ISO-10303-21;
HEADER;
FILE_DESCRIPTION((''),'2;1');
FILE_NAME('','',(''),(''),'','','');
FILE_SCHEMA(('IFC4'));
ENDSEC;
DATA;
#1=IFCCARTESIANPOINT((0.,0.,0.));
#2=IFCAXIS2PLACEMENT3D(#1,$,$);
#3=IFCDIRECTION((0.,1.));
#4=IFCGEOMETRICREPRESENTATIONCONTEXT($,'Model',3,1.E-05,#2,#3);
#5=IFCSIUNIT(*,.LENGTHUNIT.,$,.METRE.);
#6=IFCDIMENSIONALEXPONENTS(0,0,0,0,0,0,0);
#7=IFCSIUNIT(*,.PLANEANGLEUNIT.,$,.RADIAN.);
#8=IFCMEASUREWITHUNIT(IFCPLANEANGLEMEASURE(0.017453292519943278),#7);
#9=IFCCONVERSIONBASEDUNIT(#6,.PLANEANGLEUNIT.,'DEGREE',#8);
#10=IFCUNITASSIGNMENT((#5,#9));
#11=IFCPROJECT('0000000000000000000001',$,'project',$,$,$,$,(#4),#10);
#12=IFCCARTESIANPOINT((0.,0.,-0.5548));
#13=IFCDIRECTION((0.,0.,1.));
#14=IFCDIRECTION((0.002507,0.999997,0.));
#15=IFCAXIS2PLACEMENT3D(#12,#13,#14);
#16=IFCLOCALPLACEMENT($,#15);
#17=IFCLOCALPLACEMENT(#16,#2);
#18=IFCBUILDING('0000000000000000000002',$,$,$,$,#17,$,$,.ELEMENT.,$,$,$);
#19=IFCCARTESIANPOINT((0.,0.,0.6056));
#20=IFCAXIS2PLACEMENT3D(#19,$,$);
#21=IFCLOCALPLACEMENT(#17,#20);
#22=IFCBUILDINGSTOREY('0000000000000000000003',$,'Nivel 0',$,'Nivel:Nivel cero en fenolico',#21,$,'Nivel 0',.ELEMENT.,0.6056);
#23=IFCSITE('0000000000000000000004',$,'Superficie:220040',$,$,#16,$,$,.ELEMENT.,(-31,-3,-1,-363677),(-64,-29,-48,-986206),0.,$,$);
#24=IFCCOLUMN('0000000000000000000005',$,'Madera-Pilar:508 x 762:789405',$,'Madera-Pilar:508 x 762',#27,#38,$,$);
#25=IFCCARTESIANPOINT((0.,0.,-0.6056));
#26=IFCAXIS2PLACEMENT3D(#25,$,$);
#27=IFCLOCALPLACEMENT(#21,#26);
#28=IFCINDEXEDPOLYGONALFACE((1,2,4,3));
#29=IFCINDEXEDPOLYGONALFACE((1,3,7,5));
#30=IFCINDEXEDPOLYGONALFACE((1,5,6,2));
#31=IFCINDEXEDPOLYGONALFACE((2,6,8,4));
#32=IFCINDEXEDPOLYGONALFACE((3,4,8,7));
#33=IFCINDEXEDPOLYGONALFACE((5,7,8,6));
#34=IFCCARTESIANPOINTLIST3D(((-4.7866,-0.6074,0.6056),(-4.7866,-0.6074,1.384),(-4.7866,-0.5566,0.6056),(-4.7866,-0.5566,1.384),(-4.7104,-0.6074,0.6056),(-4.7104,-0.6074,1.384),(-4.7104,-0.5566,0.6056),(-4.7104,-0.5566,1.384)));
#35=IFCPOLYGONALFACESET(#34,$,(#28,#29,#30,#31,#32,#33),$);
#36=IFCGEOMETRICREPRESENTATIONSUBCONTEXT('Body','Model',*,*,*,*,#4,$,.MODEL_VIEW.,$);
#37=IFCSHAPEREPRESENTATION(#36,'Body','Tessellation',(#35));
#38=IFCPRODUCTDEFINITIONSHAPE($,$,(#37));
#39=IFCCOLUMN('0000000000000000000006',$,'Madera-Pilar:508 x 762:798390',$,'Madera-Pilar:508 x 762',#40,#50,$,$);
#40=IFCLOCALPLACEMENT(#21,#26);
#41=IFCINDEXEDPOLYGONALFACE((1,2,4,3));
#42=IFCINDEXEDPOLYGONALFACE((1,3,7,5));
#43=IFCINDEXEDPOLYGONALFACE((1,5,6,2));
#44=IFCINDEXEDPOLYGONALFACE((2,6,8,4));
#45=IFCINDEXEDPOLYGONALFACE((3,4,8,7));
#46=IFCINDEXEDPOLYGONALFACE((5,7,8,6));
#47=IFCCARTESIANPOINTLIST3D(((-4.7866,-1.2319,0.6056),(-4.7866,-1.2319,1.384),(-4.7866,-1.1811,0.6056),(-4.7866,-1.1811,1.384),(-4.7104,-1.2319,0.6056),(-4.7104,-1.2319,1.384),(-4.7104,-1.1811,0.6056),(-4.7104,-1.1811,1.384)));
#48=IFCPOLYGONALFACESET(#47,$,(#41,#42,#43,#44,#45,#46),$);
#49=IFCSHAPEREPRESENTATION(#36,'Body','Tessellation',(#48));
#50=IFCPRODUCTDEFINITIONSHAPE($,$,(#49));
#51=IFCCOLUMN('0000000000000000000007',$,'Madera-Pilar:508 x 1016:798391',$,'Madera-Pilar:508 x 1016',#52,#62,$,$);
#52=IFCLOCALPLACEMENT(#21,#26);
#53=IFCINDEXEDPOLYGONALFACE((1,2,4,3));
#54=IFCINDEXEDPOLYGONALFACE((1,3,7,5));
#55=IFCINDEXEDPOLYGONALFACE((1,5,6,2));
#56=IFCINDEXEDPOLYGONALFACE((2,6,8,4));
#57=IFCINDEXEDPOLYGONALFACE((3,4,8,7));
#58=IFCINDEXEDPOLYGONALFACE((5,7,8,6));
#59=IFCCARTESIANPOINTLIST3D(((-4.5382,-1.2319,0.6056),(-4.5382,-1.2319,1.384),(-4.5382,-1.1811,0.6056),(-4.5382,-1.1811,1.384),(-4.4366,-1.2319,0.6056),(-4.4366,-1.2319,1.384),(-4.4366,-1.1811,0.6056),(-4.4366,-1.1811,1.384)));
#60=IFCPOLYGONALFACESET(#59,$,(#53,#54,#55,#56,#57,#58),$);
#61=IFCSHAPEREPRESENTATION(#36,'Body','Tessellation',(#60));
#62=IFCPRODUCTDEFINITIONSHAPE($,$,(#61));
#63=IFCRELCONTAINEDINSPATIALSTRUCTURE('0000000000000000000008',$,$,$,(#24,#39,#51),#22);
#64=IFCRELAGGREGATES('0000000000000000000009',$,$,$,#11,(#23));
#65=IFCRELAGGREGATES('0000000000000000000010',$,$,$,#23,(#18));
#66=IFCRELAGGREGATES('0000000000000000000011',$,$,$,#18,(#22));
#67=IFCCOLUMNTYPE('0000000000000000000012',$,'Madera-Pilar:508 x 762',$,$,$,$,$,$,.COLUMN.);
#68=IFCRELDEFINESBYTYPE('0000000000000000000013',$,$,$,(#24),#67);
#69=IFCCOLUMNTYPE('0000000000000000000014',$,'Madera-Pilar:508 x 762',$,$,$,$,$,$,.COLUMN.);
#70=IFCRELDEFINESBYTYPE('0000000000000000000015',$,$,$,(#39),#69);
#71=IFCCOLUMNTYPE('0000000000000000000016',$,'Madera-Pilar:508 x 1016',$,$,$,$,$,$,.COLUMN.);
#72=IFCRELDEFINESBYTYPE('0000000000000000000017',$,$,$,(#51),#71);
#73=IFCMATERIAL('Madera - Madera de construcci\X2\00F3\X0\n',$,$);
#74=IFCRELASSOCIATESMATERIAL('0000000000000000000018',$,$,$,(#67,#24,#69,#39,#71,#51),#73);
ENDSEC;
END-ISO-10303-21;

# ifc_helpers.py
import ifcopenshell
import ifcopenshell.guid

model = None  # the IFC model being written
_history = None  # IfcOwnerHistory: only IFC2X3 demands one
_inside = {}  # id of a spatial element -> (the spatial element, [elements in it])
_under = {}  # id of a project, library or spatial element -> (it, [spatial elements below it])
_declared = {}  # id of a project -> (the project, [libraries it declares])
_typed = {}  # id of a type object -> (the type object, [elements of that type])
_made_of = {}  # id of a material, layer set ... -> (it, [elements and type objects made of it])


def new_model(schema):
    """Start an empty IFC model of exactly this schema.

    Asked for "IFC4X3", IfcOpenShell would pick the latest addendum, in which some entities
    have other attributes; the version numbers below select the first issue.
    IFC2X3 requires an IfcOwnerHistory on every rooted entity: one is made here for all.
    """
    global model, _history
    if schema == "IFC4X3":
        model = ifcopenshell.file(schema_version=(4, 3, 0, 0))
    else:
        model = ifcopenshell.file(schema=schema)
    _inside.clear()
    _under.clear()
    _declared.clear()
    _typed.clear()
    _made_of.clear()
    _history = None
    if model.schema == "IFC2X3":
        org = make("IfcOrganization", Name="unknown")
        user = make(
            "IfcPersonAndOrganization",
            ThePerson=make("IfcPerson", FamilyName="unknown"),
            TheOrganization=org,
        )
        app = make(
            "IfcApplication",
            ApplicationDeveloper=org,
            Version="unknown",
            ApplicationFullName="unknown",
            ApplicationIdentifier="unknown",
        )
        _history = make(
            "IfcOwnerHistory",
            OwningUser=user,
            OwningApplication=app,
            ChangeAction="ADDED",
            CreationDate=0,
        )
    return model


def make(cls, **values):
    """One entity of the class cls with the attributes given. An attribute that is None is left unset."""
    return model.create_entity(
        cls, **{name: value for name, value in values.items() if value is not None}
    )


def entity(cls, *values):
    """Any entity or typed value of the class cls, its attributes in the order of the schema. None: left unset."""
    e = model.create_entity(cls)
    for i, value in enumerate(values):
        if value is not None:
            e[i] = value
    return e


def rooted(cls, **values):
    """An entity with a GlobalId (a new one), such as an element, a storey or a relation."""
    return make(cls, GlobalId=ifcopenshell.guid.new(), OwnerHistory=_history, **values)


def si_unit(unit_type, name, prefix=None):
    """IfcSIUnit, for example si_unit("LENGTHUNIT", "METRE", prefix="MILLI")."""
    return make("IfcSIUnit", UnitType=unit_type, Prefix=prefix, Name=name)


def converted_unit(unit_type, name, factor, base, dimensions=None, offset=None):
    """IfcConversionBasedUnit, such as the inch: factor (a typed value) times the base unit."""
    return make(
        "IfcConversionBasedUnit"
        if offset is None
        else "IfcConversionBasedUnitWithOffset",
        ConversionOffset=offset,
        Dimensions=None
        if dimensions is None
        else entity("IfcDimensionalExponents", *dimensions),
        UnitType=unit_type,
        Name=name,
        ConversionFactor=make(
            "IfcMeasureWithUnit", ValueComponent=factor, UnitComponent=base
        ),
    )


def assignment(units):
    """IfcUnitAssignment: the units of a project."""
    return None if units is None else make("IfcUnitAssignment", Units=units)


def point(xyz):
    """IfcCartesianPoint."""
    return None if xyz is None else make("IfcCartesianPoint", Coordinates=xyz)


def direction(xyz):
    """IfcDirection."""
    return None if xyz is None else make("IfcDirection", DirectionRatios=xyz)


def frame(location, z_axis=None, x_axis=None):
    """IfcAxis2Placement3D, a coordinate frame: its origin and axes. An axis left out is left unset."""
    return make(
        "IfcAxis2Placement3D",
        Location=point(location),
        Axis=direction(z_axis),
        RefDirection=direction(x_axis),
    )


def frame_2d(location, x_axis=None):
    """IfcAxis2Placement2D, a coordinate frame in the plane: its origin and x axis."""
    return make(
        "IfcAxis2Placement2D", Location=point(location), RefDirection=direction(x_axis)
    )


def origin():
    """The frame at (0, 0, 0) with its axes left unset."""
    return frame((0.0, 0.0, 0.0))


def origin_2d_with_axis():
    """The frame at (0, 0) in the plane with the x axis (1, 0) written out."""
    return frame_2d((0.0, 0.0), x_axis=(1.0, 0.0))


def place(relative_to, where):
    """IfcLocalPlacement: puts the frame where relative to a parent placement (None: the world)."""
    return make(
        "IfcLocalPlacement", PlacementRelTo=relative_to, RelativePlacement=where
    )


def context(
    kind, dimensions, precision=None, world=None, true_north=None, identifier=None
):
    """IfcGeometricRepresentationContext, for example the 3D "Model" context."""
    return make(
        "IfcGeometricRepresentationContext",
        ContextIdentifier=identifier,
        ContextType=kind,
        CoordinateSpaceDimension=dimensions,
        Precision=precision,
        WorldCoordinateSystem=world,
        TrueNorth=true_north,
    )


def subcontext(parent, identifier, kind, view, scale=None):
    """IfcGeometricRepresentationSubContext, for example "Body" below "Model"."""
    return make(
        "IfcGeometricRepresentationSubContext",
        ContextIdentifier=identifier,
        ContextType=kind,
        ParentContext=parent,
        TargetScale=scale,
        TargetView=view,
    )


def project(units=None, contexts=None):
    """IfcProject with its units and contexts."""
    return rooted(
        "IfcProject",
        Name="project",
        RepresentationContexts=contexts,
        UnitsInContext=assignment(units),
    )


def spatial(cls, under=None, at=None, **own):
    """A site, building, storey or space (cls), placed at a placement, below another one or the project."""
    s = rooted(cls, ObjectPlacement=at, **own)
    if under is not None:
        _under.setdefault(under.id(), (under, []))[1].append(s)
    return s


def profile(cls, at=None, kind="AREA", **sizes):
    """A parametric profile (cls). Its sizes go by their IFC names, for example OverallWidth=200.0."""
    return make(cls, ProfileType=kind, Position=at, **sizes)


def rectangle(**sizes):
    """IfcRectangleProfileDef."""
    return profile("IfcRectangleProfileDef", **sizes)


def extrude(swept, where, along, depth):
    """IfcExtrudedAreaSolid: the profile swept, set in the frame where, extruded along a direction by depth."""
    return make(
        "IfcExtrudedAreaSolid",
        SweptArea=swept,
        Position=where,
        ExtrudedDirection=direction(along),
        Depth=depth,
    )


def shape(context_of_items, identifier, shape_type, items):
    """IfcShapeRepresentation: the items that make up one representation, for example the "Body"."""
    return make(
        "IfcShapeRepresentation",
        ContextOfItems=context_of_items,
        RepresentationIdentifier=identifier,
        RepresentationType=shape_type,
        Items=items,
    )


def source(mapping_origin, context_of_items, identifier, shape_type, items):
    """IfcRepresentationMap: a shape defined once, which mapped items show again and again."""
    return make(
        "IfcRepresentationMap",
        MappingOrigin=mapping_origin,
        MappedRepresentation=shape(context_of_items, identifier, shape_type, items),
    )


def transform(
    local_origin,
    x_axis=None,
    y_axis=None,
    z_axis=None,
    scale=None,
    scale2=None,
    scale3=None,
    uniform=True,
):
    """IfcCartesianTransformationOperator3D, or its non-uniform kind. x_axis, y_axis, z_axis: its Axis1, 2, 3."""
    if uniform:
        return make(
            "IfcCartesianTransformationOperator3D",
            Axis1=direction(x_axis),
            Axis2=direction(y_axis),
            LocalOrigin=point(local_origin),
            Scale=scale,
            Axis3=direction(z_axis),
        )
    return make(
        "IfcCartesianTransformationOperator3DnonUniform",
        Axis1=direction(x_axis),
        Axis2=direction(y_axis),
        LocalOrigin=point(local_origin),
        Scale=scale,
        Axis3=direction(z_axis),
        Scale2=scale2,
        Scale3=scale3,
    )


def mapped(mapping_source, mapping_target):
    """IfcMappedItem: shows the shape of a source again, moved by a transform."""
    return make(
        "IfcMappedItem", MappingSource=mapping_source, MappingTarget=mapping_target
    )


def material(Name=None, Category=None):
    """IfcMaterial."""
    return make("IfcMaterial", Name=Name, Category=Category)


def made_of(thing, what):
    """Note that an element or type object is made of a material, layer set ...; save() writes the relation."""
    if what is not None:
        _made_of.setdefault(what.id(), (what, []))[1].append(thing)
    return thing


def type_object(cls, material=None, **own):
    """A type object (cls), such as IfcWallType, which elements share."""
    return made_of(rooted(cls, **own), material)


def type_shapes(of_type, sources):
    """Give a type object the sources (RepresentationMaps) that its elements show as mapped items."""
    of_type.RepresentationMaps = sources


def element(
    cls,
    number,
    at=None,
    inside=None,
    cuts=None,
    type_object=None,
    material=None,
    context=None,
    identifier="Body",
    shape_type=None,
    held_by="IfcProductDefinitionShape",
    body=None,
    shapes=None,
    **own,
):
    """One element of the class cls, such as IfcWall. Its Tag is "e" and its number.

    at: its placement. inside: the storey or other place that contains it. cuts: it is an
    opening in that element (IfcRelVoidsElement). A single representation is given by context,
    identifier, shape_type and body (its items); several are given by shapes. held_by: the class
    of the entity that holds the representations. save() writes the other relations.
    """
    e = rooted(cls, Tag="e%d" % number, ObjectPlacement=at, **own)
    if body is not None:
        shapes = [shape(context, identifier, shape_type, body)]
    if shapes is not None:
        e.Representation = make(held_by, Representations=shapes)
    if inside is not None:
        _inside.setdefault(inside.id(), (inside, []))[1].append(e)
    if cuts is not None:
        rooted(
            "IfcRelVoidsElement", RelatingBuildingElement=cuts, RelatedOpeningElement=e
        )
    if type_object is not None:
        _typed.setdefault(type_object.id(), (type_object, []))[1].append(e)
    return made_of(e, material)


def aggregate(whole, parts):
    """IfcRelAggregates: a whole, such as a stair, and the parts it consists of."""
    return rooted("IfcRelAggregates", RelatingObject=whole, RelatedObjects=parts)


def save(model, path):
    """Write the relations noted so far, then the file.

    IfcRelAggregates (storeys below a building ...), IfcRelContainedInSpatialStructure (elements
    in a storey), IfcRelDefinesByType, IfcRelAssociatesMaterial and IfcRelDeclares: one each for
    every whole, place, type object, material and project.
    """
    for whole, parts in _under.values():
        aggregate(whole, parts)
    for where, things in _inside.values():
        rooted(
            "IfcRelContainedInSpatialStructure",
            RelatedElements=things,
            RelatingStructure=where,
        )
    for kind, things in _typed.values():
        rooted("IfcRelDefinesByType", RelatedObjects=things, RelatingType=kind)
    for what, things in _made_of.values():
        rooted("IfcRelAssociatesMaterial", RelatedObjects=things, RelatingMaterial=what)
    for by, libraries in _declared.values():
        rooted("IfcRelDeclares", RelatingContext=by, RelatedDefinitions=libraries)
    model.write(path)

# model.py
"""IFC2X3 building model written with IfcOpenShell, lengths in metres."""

from ifc_helpers import new_model, entity, si_unit, converted_unit, direction, frame, frame_2d, origin, origin_2d_with_axis, place, context, subcontext, project, spatial, rectangle, extrude, source, transform, mapped, material, type_object, type_shapes, element, save


model = new_model("IFC2X3")

# Units and contexts
model_context = context("Model", 3, precision=1e-05, world=origin(), true_north=direction((0.0, 1.0)))
body_context = subcontext(model_context, "Body", "Model", "MODEL_VIEW")
ifc_project = project(units=[si_unit("LENGTHUNIT", "METRE"), converted_unit("PLANEANGLEUNIT", "DEGREE", entity("IfcPlaneAngleMeasure", 0.017453292519943278), si_unit("PLANEANGLEUNIT", "RADIAN"), dimensions=[0, 0, 0, 0, 0, 0, 0])], contexts=[model_context])

# Site, building, storey
site_placement = place(None, frame((0.0, 0.0, -0.5548), z_axis=(0.0, 0.0, 1.0), x_axis=(0.002507, 0.999997, 0.0)))
site = spatial("IfcSite", under=ifc_project, at=site_placement, Name="Superficie:220040", CompositionType="ELEMENT", RefLatitude=(-31, -3, -1, -363677), RefLongitude=(-64, -29, -48, -986206), RefElevation=0.0)
building_placement = place(site_placement, origin())
building = spatial("IfcBuilding", under=site, at=building_placement, CompositionType="ELEMENT")
storey_placement = place(building_placement, frame((0.0, 0.0, 0.6056)))
storey = spatial("IfcBuildingStorey", under=building, at=storey_placement, Name="Nivel 0", ObjectType="Nivel:Nivel cero en fenolico", LongName="Nivel 0", CompositionType="ELEMENT", Elevation=0.6056)

# Columns
ifc_material = material(Name="Madera - Madera de construcción")
column_type_1 = type_object("IfcColumnType", Name="Madera-Pilar:508 x 762", PredefinedType="COLUMN", material=ifc_material)
shared_shape_1 = source(origin(), body_context, "Body", "SweptSolid", [
    extrude(rectangle(XDim=0.0762, YDim=0.0508, at=origin_2d_with_axis()), frame((-4.7485, -0.582, 0.6056), z_axis=(0.0, 0.0, 1.0), x_axis=(-1.0, 0.0, 0.0)), (0.0, 0.0, 1.0), 0.7784),
])
type_shapes(column_type_1, [shared_shape_1])
column_1_placement = place(storey_placement, frame((0.0, 0.0, -0.6056)))
element("IfcColumn", 1, at=column_1_placement, inside=storey, type_object=column_type_1, material=ifc_material, Name="Madera-Pilar:508 x 762:789405", ObjectType="Madera-Pilar:508 x 762", context=body_context, shape_type="MappedRepresentation", body=[
    mapped(shared_shape_1, transform((0.0, 0.0, 0.0), scale=1.0)),
])
column_type_2 = type_object("IfcColumnType", Name="Madera-Pilar:508 x 762", PredefinedType="COLUMN", material=ifc_material)
shared_shape_2 = source(origin(), body_context, "Body", "SweptSolid", [
    extrude(rectangle(XDim=0.0762, YDim=0.0508, at=origin_2d_with_axis()), frame((-4.7485, -1.2065, 0.6056), z_axis=(0.0, 0.0, 1.0), x_axis=(-1.0, 0.0, 0.0)), (0.0, 0.0, 1.0), 0.7784),
])
type_shapes(column_type_2, [shared_shape_2])
column_2_placement = place(storey_placement, frame((0.0, 0.0, -0.6056)))
element("IfcColumn", 2, at=column_2_placement, inside=storey, type_object=column_type_2, material=ifc_material, Name="Madera-Pilar:508 x 762:798390", ObjectType="Madera-Pilar:508 x 762", context=body_context, shape_type="MappedRepresentation", body=[
    mapped(shared_shape_2, transform((0.0, 0.0, 0.0), scale=1.0)),
])
column_type_3 = type_object("IfcColumnType", Name="Madera-Pilar:508 x 1016", PredefinedType="COLUMN", material=ifc_material)
shared_shape_3 = source(origin(), body_context, "Body", "SweptSolid", [
    extrude(rectangle(XDim=0.1016, YDim=0.0508, at=frame_2d((0.0, 0.0), x_axis=(1.0, 0.0))), frame((-4.4874, -1.2065, 0.6056), z_axis=(0.0, 0.0, 1.0), x_axis=(-1.0, 0.0, 0.0)), (0.0, 0.0, 1.0), 0.7784),
])
type_shapes(column_type_3, [shared_shape_3])
column_3_placement = place(storey_placement, frame((0.0, 0.0, -0.6056)))
element("IfcColumn", 3, at=column_3_placement, inside=storey, type_object=column_type_3, material=ifc_material, Name="Madera-Pilar:508 x 1016:798391", ObjectType="Madera-Pilar:508 x 1016", context=body_context, shape_type="MappedRepresentation", body=[
    mapped(shared_shape_3, transform((0.0, 0.0, 0.0), scale=1.0)),
])

save(model, "model.ifc")
